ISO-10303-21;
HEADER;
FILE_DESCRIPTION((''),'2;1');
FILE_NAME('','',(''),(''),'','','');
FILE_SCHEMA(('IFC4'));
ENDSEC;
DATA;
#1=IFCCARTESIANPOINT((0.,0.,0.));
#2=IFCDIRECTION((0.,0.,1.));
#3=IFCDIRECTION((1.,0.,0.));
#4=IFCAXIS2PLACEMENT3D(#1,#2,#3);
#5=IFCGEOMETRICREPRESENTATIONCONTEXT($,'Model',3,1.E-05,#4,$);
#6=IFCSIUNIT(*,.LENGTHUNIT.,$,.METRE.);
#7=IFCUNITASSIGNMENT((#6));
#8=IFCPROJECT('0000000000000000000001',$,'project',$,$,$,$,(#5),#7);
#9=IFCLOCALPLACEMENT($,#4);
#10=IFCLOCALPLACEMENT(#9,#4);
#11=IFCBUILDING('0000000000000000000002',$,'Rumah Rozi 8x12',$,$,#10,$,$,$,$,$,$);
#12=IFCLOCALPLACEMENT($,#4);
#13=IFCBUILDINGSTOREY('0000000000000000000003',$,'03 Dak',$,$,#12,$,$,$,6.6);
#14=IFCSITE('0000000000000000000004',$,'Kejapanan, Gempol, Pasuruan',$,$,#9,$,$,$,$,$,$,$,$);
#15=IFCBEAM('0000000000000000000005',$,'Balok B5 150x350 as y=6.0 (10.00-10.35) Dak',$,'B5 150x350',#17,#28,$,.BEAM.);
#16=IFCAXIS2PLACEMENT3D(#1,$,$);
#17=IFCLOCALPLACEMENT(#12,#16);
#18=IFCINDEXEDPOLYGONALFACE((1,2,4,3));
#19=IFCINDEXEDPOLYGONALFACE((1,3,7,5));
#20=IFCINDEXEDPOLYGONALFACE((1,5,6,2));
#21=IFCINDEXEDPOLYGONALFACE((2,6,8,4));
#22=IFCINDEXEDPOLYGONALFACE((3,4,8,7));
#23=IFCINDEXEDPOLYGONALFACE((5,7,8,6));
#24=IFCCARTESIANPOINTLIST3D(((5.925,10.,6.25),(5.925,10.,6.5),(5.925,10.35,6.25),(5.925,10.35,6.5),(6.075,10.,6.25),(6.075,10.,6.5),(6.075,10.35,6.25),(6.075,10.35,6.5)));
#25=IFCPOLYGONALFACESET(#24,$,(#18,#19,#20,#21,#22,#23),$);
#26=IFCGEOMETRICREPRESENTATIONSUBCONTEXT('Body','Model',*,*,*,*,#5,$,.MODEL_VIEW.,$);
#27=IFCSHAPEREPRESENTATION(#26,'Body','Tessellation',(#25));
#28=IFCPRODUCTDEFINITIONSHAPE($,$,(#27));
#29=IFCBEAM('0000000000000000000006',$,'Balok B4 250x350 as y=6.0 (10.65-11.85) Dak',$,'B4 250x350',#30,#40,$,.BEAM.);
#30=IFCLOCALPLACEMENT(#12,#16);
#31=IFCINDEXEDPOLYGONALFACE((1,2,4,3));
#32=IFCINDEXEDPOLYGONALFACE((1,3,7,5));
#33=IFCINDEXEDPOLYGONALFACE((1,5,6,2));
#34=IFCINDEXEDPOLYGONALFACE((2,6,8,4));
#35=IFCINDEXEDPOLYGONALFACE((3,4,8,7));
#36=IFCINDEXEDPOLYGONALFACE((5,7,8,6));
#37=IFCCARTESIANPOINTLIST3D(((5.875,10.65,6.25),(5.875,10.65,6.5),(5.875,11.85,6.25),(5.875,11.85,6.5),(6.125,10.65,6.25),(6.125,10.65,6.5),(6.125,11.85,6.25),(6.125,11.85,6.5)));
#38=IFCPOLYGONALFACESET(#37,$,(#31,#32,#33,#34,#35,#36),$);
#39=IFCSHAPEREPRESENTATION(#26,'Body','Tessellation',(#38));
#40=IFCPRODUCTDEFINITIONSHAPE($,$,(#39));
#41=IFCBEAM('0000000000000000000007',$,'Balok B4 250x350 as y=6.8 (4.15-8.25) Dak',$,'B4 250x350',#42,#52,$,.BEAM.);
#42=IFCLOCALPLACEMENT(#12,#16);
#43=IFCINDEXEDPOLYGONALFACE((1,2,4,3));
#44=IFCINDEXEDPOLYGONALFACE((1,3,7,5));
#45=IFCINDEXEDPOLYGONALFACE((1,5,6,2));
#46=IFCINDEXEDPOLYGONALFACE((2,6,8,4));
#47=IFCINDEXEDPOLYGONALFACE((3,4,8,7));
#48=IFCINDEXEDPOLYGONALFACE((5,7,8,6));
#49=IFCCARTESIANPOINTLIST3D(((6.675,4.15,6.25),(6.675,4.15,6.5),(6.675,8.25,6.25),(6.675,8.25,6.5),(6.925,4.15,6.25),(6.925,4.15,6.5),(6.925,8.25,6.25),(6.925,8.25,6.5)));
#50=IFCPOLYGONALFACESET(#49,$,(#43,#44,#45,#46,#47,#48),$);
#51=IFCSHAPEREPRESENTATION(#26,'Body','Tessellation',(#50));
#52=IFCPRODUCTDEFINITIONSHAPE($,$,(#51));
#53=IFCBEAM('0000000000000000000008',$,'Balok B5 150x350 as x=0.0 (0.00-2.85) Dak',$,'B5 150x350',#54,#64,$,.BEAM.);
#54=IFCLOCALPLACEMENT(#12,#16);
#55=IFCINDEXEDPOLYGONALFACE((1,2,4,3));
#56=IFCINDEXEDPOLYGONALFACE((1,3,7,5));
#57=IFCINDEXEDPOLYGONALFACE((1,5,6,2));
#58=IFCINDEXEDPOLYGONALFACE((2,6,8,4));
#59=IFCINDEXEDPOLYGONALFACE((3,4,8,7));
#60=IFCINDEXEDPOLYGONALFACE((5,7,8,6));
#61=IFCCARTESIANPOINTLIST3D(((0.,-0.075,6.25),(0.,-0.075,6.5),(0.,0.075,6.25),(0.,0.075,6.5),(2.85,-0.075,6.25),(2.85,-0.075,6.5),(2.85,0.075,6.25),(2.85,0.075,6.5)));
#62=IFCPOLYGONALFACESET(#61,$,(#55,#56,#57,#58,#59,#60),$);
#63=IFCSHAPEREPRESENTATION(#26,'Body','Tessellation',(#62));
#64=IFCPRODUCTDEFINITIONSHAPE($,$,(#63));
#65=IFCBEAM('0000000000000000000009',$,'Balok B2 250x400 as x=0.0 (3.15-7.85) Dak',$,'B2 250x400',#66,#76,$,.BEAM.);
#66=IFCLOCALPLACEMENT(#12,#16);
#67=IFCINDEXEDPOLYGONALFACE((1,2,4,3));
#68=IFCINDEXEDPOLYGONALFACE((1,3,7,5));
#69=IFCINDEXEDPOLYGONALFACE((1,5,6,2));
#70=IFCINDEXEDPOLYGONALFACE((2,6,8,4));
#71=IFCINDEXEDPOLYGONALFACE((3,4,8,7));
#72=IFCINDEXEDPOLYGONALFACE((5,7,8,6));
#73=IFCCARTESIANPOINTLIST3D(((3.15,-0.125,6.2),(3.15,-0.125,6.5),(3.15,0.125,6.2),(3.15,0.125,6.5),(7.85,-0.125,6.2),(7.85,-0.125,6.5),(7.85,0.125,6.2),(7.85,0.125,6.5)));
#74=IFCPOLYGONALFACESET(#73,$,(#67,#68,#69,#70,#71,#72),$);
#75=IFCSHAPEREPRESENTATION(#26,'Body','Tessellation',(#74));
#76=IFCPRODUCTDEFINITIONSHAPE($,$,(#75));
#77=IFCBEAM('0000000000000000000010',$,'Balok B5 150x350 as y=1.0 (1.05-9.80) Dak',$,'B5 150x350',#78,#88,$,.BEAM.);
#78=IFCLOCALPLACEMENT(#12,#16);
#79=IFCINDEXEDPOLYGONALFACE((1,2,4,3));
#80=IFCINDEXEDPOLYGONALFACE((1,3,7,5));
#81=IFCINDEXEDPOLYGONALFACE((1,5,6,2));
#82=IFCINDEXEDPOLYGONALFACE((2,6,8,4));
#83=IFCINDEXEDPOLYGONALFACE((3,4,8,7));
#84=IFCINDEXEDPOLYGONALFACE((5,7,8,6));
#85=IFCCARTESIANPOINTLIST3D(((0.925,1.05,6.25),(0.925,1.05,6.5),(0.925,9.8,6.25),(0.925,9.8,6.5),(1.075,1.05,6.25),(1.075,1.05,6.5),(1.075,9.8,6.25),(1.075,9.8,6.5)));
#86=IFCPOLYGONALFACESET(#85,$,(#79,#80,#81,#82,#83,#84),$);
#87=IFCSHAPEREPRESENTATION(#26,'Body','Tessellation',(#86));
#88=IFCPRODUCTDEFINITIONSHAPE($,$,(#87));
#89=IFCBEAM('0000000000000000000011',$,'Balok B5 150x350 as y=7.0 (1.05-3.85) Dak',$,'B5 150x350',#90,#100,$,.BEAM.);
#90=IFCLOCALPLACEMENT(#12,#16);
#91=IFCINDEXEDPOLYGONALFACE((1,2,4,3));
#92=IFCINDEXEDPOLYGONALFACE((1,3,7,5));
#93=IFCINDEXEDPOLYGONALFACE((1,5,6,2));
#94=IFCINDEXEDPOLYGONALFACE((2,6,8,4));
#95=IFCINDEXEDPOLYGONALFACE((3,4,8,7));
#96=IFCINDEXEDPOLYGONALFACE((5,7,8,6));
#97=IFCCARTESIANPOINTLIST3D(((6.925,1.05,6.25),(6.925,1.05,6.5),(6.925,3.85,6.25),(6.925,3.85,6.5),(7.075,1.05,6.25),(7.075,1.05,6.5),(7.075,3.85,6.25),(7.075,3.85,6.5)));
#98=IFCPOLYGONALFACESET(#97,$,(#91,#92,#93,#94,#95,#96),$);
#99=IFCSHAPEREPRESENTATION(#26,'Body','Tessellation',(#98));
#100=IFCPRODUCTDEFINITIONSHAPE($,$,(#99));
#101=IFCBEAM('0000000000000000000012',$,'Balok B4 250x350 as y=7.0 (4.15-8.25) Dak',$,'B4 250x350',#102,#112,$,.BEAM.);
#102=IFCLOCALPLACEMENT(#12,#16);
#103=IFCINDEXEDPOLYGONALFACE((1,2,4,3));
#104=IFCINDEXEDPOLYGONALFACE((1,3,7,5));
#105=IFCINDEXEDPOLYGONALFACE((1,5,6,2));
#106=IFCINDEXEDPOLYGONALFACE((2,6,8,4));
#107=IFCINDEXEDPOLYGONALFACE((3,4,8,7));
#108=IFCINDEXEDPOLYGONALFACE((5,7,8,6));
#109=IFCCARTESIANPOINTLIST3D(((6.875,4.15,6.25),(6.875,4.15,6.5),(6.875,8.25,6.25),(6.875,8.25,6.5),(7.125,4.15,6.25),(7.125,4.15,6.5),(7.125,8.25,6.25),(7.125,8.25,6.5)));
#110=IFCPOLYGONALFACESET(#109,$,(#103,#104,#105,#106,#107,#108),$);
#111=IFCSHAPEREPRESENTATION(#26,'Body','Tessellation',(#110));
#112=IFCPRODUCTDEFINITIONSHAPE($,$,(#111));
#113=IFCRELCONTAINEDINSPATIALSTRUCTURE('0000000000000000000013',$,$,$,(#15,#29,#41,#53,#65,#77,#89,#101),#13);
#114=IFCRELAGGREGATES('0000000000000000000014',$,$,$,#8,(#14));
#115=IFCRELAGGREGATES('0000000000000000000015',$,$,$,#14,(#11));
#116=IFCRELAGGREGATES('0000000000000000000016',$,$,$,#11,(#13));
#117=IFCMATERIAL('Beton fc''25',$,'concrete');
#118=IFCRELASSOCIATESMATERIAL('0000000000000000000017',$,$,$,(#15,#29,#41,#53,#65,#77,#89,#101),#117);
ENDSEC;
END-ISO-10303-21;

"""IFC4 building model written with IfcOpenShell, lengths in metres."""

from ifc_helpers import new_model, si_unit, frame, origin_with_axes, place, context, subcontext, project, spatial, line, indexed_curve, outline, extrude, material, element, save


model = new_model("IFC4")

# Units and contexts
model_context = context("Model", 3, precision=1e-05, world=origin_with_axes())
body_context = subcontext(model_context, "Body", "Model", "MODEL_VIEW")
ifc_project = project(units=[si_unit("LENGTHUNIT", "METRE")], contexts=[model_context])

# Site, building, storey
site_placement = place(None, origin_with_axes())
site = spatial("IfcSite", under=ifc_project, at=site_placement, Name="Kejapanan, Gempol, Pasuruan")
building_placement = place(site_placement, origin_with_axes())
building = spatial("IfcBuilding", under=site, at=building_placement, Name="Rumah Rozi 8x12")
storey_placement = place(None, origin_with_axes())
storey = spatial("IfcBuildingStorey", under=building, at=storey_placement, Name="03 Dak", Elevation=6.6)

# Beams
ifc_material = material(Name="Beton fc'25", Category="concrete")
beam_1_placement = place(storey_placement, origin_with_axes())
element("IfcBeam", 1, at=beam_1_placement, inside=storey, material=ifc_material, Name="Balok B5 150x350 as y=6.0 (10.00-10.35) Dak", ObjectType="B5 150x350", PredefinedType="BEAM", context=body_context, shape_type="SweptSolid", body=[
    extrude(outline(indexed_curve([(5.925, 10.0), (6.075, 10.0), (6.075, 10.35), (5.925, 10.35)], segments=[line(1, 2, 3, 4, 1)])), frame((0.0, 0.0, 6.25), z_axis=(0.0, 0.0, 1.0), x_axis=(1.0, 0.0, 0.0)), (0.0, 0.0, 1.0), 0.25),
])
beam_2_placement = place(storey_placement, origin_with_axes())
element("IfcBeam", 2, at=beam_2_placement, inside=storey, material=ifc_material, Name="Balok B4 250x350 as y=6.0 (10.65-11.85) Dak", ObjectType="B4 250x350", PredefinedType="BEAM", context=body_context, shape_type="SweptSolid", body=[
    extrude(outline(indexed_curve([(5.875, 10.65), (6.125, 10.65), (6.125, 11.85), (5.875, 11.85)], segments=[line(1, 2, 3, 4, 1)])), frame((0.0, 0.0, 6.25), z_axis=(0.0, 0.0, 1.0), x_axis=(1.0, 0.0, 0.0)), (0.0, 0.0, 1.0), 0.25),
])
beam_3_placement = place(storey_placement, origin_with_axes())
element("IfcBeam", 3, at=beam_3_placement, inside=storey, material=ifc_material, Name="Balok B4 250x350 as y=6.8 (4.15-8.25) Dak", ObjectType="B4 250x350", PredefinedType="BEAM", context=body_context, shape_type="SweptSolid", body=[
    extrude(outline(indexed_curve([(6.675, 4.15), (6.925, 4.15), (6.925, 8.25), (6.675, 8.25)], segments=[line(1, 2, 3, 4, 1)])), frame((0.0, 0.0, 6.25), z_axis=(0.0, 0.0, 1.0), x_axis=(1.0, 0.0, 0.0)), (0.0, 0.0, 1.0), 0.25),
])
beam_4_placement = place(storey_placement, origin_with_axes())
element("IfcBeam", 4, at=beam_4_placement, inside=storey, material=ifc_material, Name="Balok B5 150x350 as x=0.0 (0.00-2.85) Dak", ObjectType="B5 150x350", PredefinedType="BEAM", context=body_context, shape_type="SweptSolid", body=[
    extrude(outline(indexed_curve([(0.0, -0.075), (2.85, -0.075), (2.85, 0.075), (0.0, 0.075)], segments=[line(1, 2, 3, 4, 1)])), frame((0.0, 0.0, 6.25), z_axis=(0.0, 0.0, 1.0), x_axis=(1.0, 0.0, 0.0)), (0.0, 0.0, 1.0), 0.25),
])
beam_5_placement = place(storey_placement, origin_with_axes())
element("IfcBeam", 5, at=beam_5_placement, inside=storey, material=ifc_material, Name="Balok B2 250x400 as x=0.0 (3.15-7.85) Dak", ObjectType="B2 250x400", PredefinedType="BEAM", context=body_context, shape_type="SweptSolid", body=[
    extrude(outline(indexed_curve([(3.15, -0.125), (7.85, -0.125), (7.85, 0.125), (3.15, 0.125)], segments=[line(1, 2, 3, 4, 1)])), frame((0.0, 0.0, 6.2), z_axis=(0.0, 0.0, 1.0), x_axis=(1.0, 0.0, 0.0)), (0.0, 0.0, 1.0), 0.3),
])
beam_6_placement = place(storey_placement, origin_with_axes())
element("IfcBeam", 6, at=beam_6_placement, inside=storey, material=ifc_material, Name="Balok B5 150x350 as y=1.0 (1.05-9.80) Dak", ObjectType="B5 150x350", PredefinedType="BEAM", context=body_context, shape_type="SweptSolid", body=[
    extrude(outline(indexed_curve([(0.925, 1.05), (1.075, 1.05), (1.075, 9.8), (0.925, 9.8)], segments=[line(1, 2, 3, 4, 1)])), frame((0.0, 0.0, 6.25), z_axis=(0.0, 0.0, 1.0), x_axis=(1.0, 0.0, 0.0)), (0.0, 0.0, 1.0), 0.25),
])
beam_7_placement = place(storey_placement, origin_with_axes())
element("IfcBeam", 7, at=beam_7_placement, inside=storey, material=ifc_material, Name="Balok B5 150x350 as y=7.0 (1.05-3.85) Dak", ObjectType="B5 150x350", PredefinedType="BEAM", context=body_context, shape_type="SweptSolid", body=[
    extrude(outline(indexed_curve([(6.925, 1.05), (7.075, 1.05), (7.075, 3.85), (6.925, 3.85)], segments=[line(1, 2, 3, 4, 1)])), frame((0.0, 0.0, 6.25), z_axis=(0.0, 0.0, 1.0), x_axis=(1.0, 0.0, 0.0)), (0.0, 0.0, 1.0), 0.25),
])
beam_8_placement = place(storey_placement, origin_with_axes())
element("IfcBeam", 8, at=beam_8_placement, inside=storey, material=ifc_material, Name="Balok B4 250x350 as y=7.0 (4.15-8.25) Dak", ObjectType="B4 250x350", PredefinedType="BEAM", context=body_context, shape_type="SweptSolid", body=[
    extrude(outline(indexed_curve([(6.875, 4.15), (7.125, 4.15), (7.125, 8.25), (6.875, 8.25)], segments=[line(1, 2, 3, 4, 1)])), frame((0.0, 0.0, 6.25), z_axis=(0.0, 0.0, 1.0), x_axis=(1.0, 0.0, 0.0)), (0.0, 0.0, 1.0), 0.25),
])

save(model, "model.ifc")
